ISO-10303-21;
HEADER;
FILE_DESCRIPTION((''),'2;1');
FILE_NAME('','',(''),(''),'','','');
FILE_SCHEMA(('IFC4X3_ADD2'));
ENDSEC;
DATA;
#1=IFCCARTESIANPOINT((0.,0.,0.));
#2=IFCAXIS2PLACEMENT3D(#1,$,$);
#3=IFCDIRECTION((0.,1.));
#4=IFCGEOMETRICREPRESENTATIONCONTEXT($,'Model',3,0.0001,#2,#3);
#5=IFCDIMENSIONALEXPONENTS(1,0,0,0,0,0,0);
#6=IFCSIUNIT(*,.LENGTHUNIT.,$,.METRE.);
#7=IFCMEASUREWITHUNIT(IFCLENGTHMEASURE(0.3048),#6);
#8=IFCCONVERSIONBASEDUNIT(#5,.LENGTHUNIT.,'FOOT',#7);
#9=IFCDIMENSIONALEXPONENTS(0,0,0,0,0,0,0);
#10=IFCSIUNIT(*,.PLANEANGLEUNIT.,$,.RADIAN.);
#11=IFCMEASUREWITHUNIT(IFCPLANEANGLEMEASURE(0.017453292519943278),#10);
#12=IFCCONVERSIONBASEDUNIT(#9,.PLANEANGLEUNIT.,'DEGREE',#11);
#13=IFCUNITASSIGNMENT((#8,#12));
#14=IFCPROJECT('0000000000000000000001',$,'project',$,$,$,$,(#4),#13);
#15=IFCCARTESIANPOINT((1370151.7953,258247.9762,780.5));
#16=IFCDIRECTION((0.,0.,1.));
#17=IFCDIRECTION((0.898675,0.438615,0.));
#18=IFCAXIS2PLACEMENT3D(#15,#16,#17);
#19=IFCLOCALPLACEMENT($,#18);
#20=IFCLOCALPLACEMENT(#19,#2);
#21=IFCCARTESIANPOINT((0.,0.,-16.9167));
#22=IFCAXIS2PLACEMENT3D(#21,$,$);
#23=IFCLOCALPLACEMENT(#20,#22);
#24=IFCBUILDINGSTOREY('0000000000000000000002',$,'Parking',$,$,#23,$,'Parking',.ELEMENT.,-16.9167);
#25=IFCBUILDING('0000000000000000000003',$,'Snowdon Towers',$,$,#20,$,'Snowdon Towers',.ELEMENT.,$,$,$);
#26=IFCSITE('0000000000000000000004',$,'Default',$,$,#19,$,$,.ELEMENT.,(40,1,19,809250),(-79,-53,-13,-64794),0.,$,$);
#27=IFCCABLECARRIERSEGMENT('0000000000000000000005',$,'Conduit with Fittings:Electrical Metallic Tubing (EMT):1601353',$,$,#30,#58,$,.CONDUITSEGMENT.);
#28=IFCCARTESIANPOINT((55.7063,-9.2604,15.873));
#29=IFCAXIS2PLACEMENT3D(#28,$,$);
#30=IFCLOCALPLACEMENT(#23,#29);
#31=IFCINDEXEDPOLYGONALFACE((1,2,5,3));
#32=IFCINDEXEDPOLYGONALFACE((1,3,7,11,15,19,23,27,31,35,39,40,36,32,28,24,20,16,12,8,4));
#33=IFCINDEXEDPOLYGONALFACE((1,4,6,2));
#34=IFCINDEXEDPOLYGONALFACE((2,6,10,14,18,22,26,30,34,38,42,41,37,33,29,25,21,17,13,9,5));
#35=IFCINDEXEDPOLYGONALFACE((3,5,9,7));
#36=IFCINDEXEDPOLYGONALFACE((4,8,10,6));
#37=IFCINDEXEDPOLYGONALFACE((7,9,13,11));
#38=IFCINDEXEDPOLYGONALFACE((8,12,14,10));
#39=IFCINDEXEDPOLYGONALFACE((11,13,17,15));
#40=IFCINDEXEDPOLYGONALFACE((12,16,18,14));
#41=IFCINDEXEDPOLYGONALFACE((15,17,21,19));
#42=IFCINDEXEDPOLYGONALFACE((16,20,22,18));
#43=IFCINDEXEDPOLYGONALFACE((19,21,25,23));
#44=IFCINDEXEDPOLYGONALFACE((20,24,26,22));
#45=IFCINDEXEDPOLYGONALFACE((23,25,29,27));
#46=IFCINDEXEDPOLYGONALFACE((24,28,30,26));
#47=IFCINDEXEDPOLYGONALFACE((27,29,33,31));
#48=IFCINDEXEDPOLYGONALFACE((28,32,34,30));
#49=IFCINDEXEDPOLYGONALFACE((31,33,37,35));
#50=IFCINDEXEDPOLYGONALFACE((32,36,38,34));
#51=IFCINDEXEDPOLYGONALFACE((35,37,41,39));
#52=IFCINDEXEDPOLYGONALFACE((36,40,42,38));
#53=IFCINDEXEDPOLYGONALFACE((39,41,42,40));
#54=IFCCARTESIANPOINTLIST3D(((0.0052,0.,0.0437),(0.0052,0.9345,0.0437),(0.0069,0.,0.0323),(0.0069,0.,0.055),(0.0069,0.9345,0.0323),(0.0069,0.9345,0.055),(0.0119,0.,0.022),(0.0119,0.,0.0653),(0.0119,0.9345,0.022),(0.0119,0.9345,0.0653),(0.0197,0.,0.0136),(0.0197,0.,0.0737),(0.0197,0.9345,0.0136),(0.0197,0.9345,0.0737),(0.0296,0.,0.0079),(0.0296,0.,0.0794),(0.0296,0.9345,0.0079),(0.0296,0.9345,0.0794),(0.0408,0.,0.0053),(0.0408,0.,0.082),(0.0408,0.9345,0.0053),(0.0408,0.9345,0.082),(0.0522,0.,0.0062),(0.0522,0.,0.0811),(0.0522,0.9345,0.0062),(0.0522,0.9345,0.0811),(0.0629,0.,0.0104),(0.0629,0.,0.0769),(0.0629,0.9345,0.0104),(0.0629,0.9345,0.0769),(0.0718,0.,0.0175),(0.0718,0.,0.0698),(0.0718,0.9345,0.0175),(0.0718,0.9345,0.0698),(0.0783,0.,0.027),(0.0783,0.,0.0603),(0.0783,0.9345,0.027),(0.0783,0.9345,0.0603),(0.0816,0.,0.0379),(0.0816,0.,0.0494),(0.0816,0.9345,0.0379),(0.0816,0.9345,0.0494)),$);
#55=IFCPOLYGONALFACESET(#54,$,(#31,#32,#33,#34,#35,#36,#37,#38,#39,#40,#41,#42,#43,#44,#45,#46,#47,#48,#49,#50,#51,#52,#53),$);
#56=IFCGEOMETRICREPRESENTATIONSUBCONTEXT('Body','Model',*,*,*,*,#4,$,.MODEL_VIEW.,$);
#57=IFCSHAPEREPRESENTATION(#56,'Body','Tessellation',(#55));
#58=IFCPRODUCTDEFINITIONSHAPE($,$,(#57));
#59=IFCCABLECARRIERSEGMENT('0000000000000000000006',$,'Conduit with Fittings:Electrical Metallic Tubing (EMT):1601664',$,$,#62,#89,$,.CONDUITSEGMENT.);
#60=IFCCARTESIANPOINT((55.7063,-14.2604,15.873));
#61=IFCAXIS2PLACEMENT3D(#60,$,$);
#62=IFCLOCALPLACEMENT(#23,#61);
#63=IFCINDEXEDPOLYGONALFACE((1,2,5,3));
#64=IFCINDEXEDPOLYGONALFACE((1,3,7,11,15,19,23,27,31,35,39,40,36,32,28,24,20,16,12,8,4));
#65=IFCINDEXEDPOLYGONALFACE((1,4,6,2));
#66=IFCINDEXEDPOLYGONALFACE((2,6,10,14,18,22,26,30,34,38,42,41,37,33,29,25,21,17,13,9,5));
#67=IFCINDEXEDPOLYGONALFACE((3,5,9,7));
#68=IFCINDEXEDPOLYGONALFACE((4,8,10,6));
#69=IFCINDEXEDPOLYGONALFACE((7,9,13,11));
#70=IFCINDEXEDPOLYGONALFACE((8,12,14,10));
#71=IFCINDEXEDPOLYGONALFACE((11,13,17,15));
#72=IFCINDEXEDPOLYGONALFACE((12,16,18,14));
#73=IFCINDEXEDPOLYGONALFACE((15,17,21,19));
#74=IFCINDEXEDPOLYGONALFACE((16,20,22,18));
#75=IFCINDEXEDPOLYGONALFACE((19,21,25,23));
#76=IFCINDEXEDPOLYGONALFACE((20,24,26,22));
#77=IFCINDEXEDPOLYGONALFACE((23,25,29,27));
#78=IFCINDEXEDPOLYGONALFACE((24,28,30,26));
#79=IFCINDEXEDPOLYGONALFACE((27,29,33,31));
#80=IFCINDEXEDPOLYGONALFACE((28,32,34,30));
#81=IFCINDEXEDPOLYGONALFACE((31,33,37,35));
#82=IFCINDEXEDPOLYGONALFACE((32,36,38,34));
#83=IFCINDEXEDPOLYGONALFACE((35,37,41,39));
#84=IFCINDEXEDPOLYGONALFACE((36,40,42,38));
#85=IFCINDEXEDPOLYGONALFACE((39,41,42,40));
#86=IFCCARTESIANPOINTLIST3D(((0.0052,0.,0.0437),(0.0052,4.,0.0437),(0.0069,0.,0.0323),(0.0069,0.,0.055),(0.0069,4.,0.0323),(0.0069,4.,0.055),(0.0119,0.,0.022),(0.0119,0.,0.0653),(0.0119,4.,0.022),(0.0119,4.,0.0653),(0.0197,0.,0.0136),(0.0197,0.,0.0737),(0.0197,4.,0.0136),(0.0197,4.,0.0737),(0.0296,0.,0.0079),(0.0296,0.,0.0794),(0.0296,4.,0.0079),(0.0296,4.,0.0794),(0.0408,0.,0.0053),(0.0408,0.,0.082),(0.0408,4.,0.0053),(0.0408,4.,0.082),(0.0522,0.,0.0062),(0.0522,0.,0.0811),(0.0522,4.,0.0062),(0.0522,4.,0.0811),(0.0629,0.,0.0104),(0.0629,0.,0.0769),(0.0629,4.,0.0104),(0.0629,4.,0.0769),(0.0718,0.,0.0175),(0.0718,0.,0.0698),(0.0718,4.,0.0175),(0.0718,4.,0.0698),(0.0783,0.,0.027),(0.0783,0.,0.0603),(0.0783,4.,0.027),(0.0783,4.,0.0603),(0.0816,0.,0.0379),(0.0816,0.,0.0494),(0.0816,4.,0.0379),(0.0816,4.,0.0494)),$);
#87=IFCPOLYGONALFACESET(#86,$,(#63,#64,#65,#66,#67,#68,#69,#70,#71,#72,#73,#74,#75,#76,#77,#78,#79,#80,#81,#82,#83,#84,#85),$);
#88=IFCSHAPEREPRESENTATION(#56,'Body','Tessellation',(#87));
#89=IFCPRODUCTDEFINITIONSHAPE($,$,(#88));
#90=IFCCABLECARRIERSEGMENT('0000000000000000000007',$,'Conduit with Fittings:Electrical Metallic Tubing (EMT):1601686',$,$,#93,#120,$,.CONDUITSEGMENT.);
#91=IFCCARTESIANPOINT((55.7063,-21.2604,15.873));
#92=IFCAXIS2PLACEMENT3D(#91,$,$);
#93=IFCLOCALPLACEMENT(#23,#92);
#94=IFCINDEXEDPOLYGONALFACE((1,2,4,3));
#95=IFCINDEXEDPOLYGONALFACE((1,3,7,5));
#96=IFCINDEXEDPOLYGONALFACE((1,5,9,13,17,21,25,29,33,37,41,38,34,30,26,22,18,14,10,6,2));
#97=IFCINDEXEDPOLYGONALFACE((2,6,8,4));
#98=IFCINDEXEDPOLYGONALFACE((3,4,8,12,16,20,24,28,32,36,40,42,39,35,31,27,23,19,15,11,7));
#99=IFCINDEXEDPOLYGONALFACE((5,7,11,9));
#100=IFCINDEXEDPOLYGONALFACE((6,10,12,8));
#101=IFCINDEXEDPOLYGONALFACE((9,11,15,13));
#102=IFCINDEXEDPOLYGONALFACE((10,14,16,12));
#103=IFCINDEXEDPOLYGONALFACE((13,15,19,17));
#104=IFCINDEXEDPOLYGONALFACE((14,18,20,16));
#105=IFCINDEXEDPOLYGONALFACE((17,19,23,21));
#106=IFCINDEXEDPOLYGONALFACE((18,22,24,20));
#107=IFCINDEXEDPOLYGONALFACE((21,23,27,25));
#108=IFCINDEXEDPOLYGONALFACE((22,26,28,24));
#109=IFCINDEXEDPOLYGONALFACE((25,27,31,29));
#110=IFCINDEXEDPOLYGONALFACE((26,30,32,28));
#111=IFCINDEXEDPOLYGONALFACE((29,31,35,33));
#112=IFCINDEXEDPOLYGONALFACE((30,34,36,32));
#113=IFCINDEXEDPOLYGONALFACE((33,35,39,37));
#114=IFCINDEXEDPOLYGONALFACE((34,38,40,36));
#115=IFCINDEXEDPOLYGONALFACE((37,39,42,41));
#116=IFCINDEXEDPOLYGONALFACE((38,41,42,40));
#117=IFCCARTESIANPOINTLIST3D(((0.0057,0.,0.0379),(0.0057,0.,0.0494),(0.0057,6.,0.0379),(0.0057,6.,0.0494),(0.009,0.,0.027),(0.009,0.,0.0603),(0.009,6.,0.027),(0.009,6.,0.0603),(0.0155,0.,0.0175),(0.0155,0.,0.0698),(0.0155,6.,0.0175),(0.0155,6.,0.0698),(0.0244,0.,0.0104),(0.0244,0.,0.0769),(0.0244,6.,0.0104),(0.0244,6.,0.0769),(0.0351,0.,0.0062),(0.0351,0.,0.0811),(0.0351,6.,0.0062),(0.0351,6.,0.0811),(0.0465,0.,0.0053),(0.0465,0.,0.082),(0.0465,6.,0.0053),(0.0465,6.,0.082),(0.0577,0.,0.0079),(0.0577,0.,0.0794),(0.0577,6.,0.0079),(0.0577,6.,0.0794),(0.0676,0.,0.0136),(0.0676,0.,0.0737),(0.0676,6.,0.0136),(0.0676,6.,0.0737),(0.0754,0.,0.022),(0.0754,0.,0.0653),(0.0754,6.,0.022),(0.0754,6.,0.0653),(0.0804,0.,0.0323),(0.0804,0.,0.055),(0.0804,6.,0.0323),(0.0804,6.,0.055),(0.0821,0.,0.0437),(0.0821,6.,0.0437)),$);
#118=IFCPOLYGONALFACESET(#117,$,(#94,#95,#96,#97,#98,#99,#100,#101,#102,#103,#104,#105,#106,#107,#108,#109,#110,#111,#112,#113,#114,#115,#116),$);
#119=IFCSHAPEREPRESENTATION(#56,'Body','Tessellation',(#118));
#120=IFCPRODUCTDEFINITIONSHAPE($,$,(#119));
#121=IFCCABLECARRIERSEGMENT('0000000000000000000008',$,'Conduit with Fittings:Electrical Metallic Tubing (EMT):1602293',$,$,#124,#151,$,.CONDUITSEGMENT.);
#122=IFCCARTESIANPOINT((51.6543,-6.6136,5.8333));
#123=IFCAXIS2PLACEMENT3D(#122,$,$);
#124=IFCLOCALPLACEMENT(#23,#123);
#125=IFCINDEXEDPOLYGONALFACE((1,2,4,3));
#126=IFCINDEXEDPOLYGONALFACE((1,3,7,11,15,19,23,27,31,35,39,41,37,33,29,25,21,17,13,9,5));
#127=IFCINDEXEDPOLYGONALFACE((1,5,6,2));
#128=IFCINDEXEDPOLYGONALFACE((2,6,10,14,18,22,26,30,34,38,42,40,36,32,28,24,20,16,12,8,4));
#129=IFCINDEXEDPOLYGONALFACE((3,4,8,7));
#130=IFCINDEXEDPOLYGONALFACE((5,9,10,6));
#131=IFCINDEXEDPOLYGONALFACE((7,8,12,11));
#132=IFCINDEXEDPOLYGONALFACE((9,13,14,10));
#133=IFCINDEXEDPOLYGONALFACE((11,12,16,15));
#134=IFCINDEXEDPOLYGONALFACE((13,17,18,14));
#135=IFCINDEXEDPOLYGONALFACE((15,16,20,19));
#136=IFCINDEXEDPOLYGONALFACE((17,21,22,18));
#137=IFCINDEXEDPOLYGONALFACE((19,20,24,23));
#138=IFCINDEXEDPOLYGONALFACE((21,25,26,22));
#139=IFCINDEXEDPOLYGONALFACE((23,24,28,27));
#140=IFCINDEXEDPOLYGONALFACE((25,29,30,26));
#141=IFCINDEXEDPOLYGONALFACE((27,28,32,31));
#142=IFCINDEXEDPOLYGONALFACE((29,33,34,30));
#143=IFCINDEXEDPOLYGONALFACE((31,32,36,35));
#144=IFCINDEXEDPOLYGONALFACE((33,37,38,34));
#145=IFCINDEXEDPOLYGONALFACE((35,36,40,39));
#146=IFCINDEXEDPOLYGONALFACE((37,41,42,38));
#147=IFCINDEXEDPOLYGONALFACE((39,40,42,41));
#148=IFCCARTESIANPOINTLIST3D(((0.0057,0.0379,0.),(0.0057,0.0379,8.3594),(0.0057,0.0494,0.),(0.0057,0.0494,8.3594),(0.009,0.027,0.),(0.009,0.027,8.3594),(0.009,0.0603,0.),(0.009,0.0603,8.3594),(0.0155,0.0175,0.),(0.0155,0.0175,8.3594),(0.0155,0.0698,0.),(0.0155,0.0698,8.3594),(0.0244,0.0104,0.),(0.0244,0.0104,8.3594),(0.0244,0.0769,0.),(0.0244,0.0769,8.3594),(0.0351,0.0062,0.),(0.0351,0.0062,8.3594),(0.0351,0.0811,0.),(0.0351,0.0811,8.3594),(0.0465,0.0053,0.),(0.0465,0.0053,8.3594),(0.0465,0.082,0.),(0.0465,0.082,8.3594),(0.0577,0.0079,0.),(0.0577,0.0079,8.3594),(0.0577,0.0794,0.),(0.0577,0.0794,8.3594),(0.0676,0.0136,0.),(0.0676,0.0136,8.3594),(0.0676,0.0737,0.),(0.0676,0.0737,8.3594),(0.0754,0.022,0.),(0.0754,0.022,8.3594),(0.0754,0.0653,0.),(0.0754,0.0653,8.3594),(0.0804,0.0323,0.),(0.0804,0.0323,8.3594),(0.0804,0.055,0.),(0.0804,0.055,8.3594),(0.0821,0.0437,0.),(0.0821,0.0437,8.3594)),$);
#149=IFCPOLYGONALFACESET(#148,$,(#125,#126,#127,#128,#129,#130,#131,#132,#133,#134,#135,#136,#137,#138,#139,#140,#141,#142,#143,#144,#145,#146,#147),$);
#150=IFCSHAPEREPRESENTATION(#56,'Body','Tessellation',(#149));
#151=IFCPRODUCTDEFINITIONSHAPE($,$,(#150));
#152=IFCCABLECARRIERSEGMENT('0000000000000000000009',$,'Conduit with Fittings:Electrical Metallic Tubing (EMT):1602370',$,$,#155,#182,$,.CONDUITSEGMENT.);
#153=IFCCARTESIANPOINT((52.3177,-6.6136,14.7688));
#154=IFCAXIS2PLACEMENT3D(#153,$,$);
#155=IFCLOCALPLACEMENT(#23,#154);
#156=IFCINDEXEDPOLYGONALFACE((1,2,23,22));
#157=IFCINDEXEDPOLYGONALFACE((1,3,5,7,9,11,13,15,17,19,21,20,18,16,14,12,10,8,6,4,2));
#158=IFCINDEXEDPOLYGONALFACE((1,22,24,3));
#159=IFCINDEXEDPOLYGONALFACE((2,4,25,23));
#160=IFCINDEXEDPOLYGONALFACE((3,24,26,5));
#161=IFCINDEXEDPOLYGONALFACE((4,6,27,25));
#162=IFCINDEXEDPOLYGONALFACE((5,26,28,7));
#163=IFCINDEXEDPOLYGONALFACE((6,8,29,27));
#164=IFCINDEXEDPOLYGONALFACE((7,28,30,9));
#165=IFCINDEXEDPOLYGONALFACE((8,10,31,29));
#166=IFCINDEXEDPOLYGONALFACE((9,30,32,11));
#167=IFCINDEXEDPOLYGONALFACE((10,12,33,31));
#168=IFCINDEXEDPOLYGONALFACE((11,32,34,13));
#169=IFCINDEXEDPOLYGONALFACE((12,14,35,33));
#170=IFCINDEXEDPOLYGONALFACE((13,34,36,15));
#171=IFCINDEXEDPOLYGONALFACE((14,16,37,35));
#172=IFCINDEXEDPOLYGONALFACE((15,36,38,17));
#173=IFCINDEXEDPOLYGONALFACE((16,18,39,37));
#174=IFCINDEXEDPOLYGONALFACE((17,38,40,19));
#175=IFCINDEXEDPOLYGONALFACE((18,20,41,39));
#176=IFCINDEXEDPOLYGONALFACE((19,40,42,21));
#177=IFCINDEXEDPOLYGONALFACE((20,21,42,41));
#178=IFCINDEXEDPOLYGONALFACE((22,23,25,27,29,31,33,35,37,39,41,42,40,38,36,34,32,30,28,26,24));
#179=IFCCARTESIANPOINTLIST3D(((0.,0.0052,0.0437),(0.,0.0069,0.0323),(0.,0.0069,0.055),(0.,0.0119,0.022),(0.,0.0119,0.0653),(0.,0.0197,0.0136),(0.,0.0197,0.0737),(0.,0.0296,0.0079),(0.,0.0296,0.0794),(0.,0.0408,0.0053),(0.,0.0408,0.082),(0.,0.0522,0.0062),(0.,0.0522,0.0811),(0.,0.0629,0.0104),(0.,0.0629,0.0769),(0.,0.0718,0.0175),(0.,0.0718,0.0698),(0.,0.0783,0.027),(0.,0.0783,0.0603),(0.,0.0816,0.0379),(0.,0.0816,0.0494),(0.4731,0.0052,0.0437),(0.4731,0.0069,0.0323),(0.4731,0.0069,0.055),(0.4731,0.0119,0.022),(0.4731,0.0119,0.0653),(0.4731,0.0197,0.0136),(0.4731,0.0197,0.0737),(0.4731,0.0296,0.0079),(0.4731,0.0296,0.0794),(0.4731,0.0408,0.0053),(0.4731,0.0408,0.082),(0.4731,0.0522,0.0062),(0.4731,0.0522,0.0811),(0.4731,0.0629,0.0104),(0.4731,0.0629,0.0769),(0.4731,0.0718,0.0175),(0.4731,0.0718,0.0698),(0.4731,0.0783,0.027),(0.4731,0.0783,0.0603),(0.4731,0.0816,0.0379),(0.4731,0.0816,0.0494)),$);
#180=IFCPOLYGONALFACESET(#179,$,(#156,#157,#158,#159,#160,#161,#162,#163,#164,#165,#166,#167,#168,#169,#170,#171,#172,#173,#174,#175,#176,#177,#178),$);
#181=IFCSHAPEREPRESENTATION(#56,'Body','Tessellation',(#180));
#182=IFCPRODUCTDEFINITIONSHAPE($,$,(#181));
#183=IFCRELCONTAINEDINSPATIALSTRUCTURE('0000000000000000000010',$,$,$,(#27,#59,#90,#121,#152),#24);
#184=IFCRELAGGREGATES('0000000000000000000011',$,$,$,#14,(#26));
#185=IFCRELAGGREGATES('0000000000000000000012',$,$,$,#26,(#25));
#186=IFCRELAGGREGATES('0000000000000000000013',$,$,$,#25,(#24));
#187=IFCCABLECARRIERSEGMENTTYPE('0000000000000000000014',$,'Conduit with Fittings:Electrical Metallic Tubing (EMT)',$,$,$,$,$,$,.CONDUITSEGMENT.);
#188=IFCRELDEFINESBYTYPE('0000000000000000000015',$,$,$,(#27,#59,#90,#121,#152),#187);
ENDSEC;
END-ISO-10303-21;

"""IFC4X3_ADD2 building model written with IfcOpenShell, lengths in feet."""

from ifc_helpers import new_model, entity, si_unit, converted_unit, direction, frame, frame_2d, origin, origin_2d_with_axis, place, context, subcontext, project, spatial, circle, extrude, type_object, element, save


model = new_model("IFC4X3_ADD2")

# Units and contexts
model_context = context("Model", 3, precision=0.0001, world=origin(), true_north=direction((0.0, 1.0)))
body_context = subcontext(model_context, "Body", "Model", "MODEL_VIEW")
ifc_project = project(units=[converted_unit("LENGTHUNIT", "FOOT", entity("IfcLengthMeasure", 0.3048), si_unit("LENGTHUNIT", "METRE"), dimensions=[1, 0, 0, 0, 0, 0, 0]), converted_unit("PLANEANGLEUNIT", "DEGREE", entity("IfcPlaneAngleMeasure", 0.017453292519943278), si_unit("PLANEANGLEUNIT", "RADIAN"), dimensions=[0, 0, 0, 0, 0, 0, 0])], contexts=[model_context])

# Site, building, storey
site_placement = place(None, frame((1370151.7953, 258247.9762, 780.5), z_axis=(0.0, 0.0, 1.0), x_axis=(0.898675, 0.438615, 0.0)))
site = spatial("IfcSite", under=ifc_project, at=site_placement, Name="Default", CompositionType="ELEMENT", RefLatitude=(40, 1, 19, 809250), RefLongitude=(-79, -53, -13, -64794), RefElevation=0.0)
building_placement = place(site_placement, origin())
building = spatial("IfcBuilding", under=site, at=building_placement, Name="Snowdon Towers", LongName="Snowdon Towers", CompositionType="ELEMENT")
storey_placement = place(building_placement, frame((0.0, 0.0, -16.9167)))
storey = spatial("IfcBuildingStorey", under=building, at=storey_placement, Name="Parking", LongName="Parking", CompositionType="ELEMENT", Elevation=-16.9167)

# Cable carrier segments
cable_carrier_segment_type_1 = type_object("IfcCableCarrierSegmentType", Name="Conduit with Fittings:Electrical Metallic Tubing (EMT)", PredefinedType="CONDUITSEGMENT")
cable_carrier_segment_1_placement = place(storey_placement, frame((55.7063, -9.2604, 15.873)))
element("IfcCableCarrierSegment", 1, at=cable_carrier_segment_1_placement, inside=storey, type_object=cable_carrier_segment_type_1, Name="Conduit with Fittings:Electrical Metallic Tubing (EMT):1601353", PredefinedType="CONDUITSEGMENT", context=body_context, shape_type="SweptSolid", body=[
    extrude(circle(Radius=0.0384, at=frame_2d((0.0, 0.0), x_axis=(1.0, 0.0))), frame((0.0437, 0.0, 0.0437), z_axis=(0.0, 1.0, 0.0), x_axis=(-1.0, 0.0, 0.0)), (0.0, 0.0, 1.0), 0.9345),
])
cable_carrier_segment_2_placement = place(storey_placement, frame((55.7063, -14.2604, 15.873)))
element("IfcCableCarrierSegment", 2, at=cable_carrier_segment_2_placement, inside=storey, type_object=cable_carrier_segment_type_1, Name="Conduit with Fittings:Electrical Metallic Tubing (EMT):1601664", PredefinedType="CONDUITSEGMENT", context=body_context, shape_type="SweptSolid", body=[
    extrude(circle(Radius=0.0384, at=frame_2d((0.0, 0.0), x_axis=(1.0, 0.0))), frame((0.0437, 0.0, 0.0437), z_axis=(0.0, 1.0, 0.0), x_axis=(-1.0, 0.0, 0.0)), (0.0, 0.0, 1.0), 4.0),
])
cable_carrier_segment_3_placement = place(storey_placement, frame((55.7063, -21.2604, 15.873)))
element("IfcCableCarrierSegment", 3, at=cable_carrier_segment_3_placement, inside=storey, type_object=cable_carrier_segment_type_1, Name="Conduit with Fittings:Electrical Metallic Tubing (EMT):1601686", PredefinedType="CONDUITSEGMENT", context=body_context, shape_type="SweptSolid", body=[
    extrude(circle(Radius=0.0384, at=frame_2d((0.0, 0.0), x_axis=(1.0, 0.0))), frame((0.0437, 0.0, 0.0437), z_axis=(0.0, 1.0, 0.0), x_axis=(1.0, 0.0, 0.0)), (0.0, 0.0, 1.0), 6.0),
])
cable_carrier_segment_4_placement = place(storey_placement, frame((51.6543, -6.6136, 5.8333)))
element("IfcCableCarrierSegment", 4, at=cable_carrier_segment_4_placement, inside=storey, type_object=cable_carrier_segment_type_1, Name="Conduit with Fittings:Electrical Metallic Tubing (EMT):1602293", PredefinedType="CONDUITSEGMENT", context=body_context, shape_type="SweptSolid", body=[
    extrude(circle(Radius=0.0384, at=frame_2d((0.0, 0.0), x_axis=(1.0, 0.0))), frame((0.0437, 0.0437, 0.0)), (0.0, 0.0, 1.0), 8.3594),
])
cable_carrier_segment_5_placement = place(storey_placement, frame((52.3177, -6.6136, 14.7688)))
element("IfcCableCarrierSegment", 5, at=cable_carrier_segment_5_placement, inside=storey, type_object=cable_carrier_segment_type_1, Name="Conduit with Fittings:Electrical Metallic Tubing (EMT):1602370", PredefinedType="CONDUITSEGMENT", context=body_context, shape_type="SweptSolid", body=[
    extrude(circle(Radius=0.0384, at=origin_2d_with_axis()), frame((0.0, 0.0437, 0.0437), z_axis=(1.0, 0.0, 0.0), x_axis=(0.0, -1.0, 0.0)), (0.0, 0.0, 1.0), 0.4731),
])

save(model, "model.ifc")
